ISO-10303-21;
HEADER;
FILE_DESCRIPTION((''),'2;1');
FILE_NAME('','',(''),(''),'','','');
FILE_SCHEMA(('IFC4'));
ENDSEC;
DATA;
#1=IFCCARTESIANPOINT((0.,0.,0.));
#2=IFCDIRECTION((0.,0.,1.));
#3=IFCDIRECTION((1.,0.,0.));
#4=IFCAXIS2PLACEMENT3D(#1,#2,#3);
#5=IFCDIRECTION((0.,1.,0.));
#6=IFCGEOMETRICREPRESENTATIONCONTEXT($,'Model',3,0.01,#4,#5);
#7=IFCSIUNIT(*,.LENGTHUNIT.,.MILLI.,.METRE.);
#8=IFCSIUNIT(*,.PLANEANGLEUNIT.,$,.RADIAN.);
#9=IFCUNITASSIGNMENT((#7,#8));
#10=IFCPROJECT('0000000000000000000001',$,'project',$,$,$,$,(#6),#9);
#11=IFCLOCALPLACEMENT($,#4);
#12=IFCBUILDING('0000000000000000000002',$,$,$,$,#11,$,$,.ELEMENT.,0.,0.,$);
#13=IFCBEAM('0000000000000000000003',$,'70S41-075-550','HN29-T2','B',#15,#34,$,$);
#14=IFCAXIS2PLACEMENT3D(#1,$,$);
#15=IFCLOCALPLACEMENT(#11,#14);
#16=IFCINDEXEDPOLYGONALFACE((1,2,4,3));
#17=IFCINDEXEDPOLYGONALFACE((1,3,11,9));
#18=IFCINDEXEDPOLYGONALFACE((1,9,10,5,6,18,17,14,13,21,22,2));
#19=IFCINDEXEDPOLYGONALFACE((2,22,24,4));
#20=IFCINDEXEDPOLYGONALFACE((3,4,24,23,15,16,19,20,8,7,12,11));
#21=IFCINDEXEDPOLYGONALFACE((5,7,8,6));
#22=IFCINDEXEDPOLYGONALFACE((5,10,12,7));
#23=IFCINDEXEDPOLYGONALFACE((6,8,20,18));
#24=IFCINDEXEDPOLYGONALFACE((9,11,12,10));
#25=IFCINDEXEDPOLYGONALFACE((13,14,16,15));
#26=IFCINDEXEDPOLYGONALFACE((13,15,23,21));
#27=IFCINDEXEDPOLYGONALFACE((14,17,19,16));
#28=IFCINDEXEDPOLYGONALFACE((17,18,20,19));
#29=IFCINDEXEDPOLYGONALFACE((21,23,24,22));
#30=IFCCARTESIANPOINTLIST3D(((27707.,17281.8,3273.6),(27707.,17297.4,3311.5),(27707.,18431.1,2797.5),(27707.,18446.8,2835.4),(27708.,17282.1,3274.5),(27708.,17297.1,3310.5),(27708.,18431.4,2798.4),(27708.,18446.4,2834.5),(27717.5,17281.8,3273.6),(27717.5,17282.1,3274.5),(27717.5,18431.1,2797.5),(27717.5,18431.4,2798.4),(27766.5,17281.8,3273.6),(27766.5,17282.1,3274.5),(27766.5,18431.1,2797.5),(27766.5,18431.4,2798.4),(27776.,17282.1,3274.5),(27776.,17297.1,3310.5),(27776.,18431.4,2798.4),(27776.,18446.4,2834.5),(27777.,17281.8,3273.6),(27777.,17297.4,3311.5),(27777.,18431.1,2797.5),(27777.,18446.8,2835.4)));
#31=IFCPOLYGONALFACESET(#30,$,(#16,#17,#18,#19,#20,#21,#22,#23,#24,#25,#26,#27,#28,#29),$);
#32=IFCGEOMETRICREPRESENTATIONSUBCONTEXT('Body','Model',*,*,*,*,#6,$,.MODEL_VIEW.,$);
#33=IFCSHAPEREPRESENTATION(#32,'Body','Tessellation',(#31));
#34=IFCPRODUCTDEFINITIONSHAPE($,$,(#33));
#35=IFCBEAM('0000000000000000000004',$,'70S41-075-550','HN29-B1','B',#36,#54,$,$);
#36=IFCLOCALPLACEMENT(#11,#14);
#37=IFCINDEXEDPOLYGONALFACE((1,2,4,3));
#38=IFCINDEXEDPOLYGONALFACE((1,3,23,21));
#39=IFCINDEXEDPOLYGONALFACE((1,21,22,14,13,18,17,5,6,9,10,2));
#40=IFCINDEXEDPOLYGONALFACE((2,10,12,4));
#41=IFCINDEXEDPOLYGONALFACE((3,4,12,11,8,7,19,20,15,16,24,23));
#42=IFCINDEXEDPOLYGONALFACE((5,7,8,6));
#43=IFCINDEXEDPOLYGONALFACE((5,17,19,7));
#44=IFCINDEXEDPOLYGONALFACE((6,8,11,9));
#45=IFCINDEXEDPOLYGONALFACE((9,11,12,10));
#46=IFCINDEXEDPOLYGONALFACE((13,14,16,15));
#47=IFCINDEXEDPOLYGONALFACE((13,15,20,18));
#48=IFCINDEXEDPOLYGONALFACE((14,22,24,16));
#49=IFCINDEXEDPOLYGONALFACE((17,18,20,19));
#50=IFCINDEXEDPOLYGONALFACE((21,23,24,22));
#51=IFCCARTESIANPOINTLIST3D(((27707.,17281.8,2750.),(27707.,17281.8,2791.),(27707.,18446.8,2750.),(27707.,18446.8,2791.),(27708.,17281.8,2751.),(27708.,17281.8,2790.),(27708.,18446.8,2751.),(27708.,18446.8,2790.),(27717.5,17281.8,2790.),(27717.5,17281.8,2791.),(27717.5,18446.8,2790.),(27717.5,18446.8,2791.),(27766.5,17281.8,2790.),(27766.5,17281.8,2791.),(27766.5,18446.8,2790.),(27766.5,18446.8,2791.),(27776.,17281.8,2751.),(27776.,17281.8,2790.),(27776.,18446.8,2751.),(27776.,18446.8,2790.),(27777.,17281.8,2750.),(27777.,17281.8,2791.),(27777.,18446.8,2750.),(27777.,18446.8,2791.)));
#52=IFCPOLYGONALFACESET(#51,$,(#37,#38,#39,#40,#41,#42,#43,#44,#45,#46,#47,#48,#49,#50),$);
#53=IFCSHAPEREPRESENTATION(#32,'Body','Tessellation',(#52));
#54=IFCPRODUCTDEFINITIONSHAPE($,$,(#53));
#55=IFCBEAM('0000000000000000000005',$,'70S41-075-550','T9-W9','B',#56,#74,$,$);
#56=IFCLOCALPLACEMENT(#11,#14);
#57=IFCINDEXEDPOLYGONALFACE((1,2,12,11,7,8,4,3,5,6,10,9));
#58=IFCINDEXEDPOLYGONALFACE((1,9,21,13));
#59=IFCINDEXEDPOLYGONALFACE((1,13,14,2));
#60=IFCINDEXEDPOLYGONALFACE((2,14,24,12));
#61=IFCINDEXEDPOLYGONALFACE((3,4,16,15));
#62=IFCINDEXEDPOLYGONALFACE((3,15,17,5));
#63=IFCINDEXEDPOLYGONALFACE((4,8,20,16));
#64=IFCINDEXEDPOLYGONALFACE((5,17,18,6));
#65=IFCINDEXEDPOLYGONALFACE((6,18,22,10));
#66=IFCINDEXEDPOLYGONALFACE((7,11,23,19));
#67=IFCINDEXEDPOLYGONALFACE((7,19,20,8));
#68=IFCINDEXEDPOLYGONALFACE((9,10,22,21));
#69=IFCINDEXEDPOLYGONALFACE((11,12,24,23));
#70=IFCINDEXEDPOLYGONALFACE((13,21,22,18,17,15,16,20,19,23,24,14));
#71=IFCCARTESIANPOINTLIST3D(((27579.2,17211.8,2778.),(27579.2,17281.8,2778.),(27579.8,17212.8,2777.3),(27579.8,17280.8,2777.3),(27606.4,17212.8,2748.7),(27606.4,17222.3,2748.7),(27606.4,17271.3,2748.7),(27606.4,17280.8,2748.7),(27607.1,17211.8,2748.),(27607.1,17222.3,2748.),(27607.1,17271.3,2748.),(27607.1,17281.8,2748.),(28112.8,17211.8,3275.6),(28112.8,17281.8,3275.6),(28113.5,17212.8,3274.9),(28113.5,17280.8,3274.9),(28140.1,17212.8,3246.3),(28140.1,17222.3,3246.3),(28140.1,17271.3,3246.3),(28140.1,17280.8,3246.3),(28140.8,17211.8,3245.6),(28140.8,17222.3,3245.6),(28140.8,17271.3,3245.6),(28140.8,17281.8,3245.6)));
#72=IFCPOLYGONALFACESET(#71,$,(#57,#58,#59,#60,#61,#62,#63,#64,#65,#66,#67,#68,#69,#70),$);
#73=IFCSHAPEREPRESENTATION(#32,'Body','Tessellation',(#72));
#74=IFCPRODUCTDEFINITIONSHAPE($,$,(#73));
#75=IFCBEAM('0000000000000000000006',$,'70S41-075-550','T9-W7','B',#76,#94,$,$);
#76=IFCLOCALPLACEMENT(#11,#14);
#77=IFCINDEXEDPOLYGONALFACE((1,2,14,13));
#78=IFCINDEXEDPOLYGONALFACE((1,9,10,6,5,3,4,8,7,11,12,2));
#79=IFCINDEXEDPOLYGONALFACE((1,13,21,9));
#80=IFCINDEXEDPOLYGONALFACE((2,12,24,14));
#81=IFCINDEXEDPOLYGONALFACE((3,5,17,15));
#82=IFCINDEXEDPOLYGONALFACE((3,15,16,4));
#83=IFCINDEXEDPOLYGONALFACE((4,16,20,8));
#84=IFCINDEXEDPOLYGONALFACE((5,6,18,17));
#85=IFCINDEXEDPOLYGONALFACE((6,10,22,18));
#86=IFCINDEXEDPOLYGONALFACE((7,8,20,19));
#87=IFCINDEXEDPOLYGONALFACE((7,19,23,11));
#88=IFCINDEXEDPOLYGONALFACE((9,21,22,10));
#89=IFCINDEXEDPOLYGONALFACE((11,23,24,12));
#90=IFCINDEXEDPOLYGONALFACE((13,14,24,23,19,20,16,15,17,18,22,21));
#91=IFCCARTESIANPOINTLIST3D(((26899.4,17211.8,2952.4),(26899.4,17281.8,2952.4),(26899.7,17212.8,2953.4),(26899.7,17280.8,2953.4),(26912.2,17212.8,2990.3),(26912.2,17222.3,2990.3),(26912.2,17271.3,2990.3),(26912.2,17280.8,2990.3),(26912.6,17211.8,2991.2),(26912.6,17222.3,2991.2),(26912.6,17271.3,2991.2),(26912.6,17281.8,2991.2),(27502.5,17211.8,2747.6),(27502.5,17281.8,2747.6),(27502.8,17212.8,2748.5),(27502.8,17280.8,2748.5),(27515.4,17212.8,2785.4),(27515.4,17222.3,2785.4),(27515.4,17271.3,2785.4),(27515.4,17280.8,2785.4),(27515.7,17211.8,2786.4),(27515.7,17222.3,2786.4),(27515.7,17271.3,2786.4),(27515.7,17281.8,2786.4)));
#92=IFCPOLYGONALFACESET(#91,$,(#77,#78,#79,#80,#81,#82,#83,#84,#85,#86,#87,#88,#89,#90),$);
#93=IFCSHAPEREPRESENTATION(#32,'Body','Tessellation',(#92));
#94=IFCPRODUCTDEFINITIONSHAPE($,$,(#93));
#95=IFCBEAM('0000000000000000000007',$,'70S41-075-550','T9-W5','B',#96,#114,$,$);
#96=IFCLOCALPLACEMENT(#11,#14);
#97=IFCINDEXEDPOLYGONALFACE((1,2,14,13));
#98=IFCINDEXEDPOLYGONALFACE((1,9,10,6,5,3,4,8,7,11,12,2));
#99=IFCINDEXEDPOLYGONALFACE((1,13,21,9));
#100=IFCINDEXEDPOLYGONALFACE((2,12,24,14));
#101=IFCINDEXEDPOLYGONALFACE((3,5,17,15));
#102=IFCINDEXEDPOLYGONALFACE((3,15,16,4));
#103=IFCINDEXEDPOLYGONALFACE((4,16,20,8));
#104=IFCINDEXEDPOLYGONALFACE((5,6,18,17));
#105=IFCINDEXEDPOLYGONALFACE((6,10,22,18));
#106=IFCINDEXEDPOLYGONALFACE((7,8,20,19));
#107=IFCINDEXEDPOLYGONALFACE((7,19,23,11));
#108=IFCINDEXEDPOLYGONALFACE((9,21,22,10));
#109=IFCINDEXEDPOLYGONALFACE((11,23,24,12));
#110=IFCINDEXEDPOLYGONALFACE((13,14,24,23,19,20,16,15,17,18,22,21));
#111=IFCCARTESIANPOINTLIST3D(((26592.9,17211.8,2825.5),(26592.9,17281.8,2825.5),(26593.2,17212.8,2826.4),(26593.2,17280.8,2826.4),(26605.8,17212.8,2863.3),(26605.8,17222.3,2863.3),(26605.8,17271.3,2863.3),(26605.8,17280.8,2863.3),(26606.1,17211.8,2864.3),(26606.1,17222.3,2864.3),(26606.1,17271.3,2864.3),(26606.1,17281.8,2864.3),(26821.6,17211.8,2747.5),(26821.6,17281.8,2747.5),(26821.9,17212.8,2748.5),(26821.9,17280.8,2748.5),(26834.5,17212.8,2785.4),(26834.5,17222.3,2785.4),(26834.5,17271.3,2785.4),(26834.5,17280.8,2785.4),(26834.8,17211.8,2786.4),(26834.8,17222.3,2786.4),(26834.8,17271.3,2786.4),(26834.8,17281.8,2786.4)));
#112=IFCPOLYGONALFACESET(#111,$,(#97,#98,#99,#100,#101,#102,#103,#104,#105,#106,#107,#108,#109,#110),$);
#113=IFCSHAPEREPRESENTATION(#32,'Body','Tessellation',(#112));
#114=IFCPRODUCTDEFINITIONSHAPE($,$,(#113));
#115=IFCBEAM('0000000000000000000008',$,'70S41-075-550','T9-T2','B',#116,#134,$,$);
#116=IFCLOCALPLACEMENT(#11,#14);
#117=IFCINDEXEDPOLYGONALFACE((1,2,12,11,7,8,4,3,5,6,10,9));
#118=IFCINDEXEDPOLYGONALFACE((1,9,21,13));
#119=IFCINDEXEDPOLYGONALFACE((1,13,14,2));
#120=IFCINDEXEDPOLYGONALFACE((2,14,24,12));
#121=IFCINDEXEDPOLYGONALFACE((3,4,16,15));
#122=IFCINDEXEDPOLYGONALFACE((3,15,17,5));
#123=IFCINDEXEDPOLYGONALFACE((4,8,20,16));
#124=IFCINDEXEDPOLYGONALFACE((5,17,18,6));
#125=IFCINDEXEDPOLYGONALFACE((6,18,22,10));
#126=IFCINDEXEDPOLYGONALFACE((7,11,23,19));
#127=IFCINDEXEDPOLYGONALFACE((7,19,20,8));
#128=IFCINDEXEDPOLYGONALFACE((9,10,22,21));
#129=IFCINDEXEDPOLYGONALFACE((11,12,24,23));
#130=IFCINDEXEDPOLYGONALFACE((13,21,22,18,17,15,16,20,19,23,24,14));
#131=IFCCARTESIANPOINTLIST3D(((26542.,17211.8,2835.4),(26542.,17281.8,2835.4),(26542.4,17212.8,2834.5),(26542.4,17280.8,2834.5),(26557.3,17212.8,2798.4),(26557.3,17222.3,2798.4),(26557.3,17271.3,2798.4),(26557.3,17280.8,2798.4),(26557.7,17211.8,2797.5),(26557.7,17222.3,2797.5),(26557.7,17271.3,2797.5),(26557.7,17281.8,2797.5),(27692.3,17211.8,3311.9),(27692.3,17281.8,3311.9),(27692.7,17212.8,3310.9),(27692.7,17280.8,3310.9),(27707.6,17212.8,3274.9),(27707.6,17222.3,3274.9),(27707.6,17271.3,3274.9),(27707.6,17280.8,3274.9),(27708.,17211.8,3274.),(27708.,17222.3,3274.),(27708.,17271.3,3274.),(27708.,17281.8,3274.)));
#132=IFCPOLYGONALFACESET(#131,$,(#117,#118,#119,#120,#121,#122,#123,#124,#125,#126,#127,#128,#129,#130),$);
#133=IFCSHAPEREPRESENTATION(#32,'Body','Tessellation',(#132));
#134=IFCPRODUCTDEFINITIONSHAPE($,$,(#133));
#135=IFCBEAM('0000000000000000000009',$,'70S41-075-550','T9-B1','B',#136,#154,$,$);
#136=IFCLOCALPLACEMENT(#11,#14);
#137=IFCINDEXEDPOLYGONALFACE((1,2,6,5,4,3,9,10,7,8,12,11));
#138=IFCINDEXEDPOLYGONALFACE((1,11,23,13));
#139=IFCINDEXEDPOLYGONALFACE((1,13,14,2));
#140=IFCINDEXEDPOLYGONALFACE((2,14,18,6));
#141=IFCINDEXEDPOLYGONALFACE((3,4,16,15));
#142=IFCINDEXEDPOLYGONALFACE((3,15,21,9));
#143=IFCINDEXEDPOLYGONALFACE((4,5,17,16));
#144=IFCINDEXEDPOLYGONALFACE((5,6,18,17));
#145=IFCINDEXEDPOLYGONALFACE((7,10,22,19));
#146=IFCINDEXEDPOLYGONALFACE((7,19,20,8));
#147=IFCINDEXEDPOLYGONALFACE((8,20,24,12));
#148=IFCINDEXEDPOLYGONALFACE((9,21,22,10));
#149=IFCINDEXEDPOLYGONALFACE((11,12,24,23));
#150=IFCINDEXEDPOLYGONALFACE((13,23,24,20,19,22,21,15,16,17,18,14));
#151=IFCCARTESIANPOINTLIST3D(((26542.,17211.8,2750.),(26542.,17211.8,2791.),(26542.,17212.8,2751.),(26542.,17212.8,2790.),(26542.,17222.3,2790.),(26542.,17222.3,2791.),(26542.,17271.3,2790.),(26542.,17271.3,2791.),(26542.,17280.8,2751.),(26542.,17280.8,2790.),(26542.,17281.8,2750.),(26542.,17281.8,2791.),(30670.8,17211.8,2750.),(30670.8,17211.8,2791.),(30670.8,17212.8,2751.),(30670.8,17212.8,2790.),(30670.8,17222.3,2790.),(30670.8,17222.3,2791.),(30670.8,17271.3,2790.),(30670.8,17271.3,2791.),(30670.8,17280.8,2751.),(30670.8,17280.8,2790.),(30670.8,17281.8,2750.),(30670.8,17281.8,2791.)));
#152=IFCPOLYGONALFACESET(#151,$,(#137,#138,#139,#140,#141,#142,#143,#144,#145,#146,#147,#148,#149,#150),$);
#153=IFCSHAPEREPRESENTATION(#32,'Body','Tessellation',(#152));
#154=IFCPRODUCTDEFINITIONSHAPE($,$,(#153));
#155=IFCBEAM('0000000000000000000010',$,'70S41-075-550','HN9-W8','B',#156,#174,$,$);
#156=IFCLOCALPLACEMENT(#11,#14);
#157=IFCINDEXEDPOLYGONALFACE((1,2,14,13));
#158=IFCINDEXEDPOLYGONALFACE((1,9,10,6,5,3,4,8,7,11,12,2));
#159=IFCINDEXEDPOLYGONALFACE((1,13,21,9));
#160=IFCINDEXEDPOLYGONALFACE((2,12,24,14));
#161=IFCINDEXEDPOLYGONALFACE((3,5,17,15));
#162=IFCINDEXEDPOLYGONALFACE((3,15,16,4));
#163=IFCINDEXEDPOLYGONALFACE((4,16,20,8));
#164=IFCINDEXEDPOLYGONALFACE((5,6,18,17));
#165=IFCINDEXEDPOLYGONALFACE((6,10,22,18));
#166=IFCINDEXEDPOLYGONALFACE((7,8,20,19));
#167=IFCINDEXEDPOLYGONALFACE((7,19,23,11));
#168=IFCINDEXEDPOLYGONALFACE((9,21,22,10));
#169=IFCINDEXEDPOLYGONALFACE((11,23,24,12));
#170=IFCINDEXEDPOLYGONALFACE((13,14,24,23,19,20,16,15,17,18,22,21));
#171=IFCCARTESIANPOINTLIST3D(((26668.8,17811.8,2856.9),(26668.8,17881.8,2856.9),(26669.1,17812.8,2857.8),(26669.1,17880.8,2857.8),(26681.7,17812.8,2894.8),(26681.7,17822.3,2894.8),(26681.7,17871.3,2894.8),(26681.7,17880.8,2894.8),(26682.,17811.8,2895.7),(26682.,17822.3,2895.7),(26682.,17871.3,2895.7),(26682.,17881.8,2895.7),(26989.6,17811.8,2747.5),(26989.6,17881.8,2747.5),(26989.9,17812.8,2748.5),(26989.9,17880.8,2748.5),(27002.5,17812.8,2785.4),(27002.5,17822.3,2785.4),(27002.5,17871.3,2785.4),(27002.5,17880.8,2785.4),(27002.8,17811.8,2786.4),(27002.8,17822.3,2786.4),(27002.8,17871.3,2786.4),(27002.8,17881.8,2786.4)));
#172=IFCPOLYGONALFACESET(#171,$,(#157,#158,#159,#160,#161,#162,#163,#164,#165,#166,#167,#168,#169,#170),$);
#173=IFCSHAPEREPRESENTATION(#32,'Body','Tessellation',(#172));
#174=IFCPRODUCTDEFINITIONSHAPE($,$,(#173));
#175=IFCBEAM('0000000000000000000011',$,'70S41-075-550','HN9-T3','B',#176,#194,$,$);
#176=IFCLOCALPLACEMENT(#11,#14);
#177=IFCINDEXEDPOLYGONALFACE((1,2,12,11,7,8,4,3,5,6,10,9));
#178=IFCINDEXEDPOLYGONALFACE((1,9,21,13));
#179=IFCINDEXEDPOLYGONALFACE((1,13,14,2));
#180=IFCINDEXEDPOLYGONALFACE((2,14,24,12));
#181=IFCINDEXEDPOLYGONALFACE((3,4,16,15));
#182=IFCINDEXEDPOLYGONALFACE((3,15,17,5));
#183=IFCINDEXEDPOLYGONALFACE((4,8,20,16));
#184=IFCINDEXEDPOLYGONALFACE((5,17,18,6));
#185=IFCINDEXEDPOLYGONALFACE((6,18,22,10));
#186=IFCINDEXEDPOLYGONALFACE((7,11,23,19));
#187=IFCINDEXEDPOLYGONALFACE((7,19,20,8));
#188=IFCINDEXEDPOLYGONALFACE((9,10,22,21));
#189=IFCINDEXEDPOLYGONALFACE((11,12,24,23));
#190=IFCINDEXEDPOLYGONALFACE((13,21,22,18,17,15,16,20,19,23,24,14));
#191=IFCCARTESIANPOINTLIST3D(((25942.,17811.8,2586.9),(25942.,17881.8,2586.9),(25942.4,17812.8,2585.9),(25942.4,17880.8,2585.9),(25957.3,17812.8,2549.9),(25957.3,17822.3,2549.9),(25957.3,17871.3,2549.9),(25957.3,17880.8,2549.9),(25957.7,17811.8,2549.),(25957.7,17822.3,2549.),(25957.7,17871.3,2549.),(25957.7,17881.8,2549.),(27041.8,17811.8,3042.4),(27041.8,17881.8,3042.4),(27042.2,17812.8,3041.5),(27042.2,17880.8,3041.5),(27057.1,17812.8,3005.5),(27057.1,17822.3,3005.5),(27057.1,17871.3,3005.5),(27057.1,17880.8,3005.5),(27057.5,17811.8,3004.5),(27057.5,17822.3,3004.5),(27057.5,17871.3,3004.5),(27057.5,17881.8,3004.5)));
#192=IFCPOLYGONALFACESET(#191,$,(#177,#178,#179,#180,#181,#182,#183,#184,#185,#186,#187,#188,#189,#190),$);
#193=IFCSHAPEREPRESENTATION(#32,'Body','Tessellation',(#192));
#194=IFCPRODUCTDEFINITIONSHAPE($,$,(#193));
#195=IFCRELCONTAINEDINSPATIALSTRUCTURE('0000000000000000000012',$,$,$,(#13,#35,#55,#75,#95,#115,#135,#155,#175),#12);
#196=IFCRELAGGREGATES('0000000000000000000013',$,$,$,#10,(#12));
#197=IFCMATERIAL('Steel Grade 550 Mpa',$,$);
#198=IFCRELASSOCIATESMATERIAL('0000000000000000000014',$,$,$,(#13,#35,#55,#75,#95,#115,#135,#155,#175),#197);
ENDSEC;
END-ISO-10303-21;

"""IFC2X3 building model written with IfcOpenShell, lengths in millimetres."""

from ifc_helpers import new_model, si_unit, direction, frame, origin, origin_with_axes, origin_2d_with_axis, place, context, subcontext, project, spatial, c_section, extrude, source, transform, mapped, material, element, save


model = new_model("IFC2X3")

# Units and contexts
model_context = context("Model", 3, precision=0.01, world=origin_with_axes(), true_north=direction((0.0, 1.0, 0.0)))
body_context = subcontext(model_context, "Body", "Model", "MODEL_VIEW")
ifc_project = project(units=[si_unit("LENGTHUNIT", "METRE", prefix="MILLI"), si_unit("PLANEANGLEUNIT", "RADIAN")], contexts=[model_context])

# Building
building_placement = place(None, origin_with_axes())
building = spatial("IfcBuilding", under=ifc_project, at=building_placement, CompositionType="ELEMENT", ElevationOfRefHeight=0.0, ElevationOfTerrain=0.0)

# Shared definitions
ifc_material = material(Name="Steel Grade 550 Mpa")

# Beams
shared_shape_1 = source(origin(), body_context, "Body", "SweptSolid", [
    extrude(c_section(Depth=70.0, Width=41.0, WallThickness=1.0, Girth=10.5, at=origin_2d_with_axis()), origin_with_axes(), (0.0, 0.0, 1.0), 1244.0),
])
beam_1_placement = place(None, frame((27742.0, 17289.6, 3292.5), z_axis=(0.0, 0.92388, -0.382683), x_axis=(0.0, -0.382683, -0.92388)))
element("IfcBeam", 1, at=beam_1_placement, inside=building, material=ifc_material, Name="70S41-075-550", Description="HN29-T2", ObjectType="B", context=body_context, shape_type="MappedRepresentation", body=[
    mapped(shared_shape_1, transform((0.0, 0.0, 0.0), scale=1.0)),
])
shared_shape_2 = source(origin(), body_context, "Body", "SweptSolid", [
    extrude(c_section(Depth=70.0, Width=41.0, WallThickness=1.0, Girth=10.5, at=origin_2d_with_axis()), origin_with_axes(), (0.0, 0.0, 1.0), 1165.0),
])
beam_2_placement = place(None, frame((27742.0, 18446.8, 2770.5), z_axis=(0.0, -1.0, 0.0), x_axis=(0.0, 0.0, 1.0)))
element("IfcBeam", 2, at=beam_2_placement, inside=building, material=ifc_material, Name="70S41-075-550", Description="HN29-B1", ObjectType="B", context=body_context, shape_type="MappedRepresentation", body=[
    mapped(shared_shape_2, transform((0.0, 0.0, 0.0), scale=1.0)),
])
shared_shape_3 = source(origin(), body_context, "Body", "SweptSolid", [
    extrude(c_section(Depth=70.0, Width=41.0, WallThickness=1.0, Girth=10.5, at=origin_2d_with_axis()), origin_with_axes(), (0.0, 0.0, 1.0), 729.7),
])
beam_3_placement = place(None, frame((28126.8, 17246.8, 3260.6), z_axis=(-0.731389, 0.0, -0.681961), x_axis=(0.681961, 0.0, -0.731389)))
element("IfcBeam", 3, at=beam_3_placement, inside=building, material=ifc_material, Name="70S41-075-550", Description="T9-W9", ObjectType="B", context=body_context, shape_type="MappedRepresentation", body=[
    mapped(shared_shape_3, transform((0.0, 0.0, 0.0), scale=1.0)),
])
shared_shape_4 = source(origin(), body_context, "Body", "SweptSolid", [
    extrude(c_section(Depth=70.0, Width=41.0, WallThickness=1.0, Girth=10.5, at=origin_2d_with_axis()), origin_with_axes(), (0.0, 0.0, 1.0), 637.0),
])
beam_4_placement = place(None, frame((26906.0, 17246.8, 2971.8), z_axis=(0.946874, 0.0, -0.321605), x_axis=(0.321605, 0.0, 0.946874)))
element("IfcBeam", 4, at=beam_4_placement, inside=building, material=ifc_material, Name="70S41-075-550", Description="T9-W7", ObjectType="B", context=body_context, shape_type="MappedRepresentation", body=[
    mapped(shared_shape_4, transform((0.0, 0.0, 0.0), scale=1.0)),
])
shared_shape_5 = source(origin(), body_context, "Body", "SweptSolid", [
    extrude(c_section(Depth=70.0, Width=41.0, WallThickness=1.0, Girth=10.5, at=origin_2d_with_axis()), origin_with_axes(), (0.0, 0.0, 1.0), 241.6),
])
beam_5_placement = place(None, frame((26599.5, 17246.8, 2844.9), z_axis=(0.9466, 0.0, -0.322409), x_axis=(0.322409, 0.0, 0.9466)))
element("IfcBeam", 5, at=beam_5_placement, inside=building, material=ifc_material, Name="70S41-075-550", Description="T9-W5", ObjectType="B", context=body_context, shape_type="MappedRepresentation", body=[
    mapped(shared_shape_5, transform((0.0, 0.0, 0.0), scale=1.0)),
])
shared_shape_6 = source(origin(), body_context, "Body", "SweptSolid", [
    extrude(c_section(Depth=70.0, Width=41.0, WallThickness=1.0, Girth=10.5, at=origin_2d_with_axis()), origin_with_axes(), (0.0, 0.0, 1.0), 1245.1),
])
beam_6_placement = place(None, frame((27700.2, 17246.8, 3292.9), z_axis=(-0.92388, 0.0, -0.382683), x_axis=(0.382683, 0.0, -0.92388)))
element("IfcBeam", 6, at=beam_6_placement, inside=building, material=ifc_material, Name="70S41-075-550", Description="T9-T2", ObjectType="B", context=body_context, shape_type="MappedRepresentation", body=[
    mapped(shared_shape_6, transform((0.0, 0.0, 0.0), scale=1.0)),
])
shared_shape_7 = source(origin(), body_context, "Body", "SweptSolid", [
    extrude(c_section(Depth=70.0, Width=41.0, WallThickness=1.0, Girth=10.5, at=origin_2d_with_axis()), origin_with_axes(), (0.0, 0.0, 1.0), 4128.8),
])
beam_7_placement = place(None, frame((26542.0, 17246.8, 2770.5), z_axis=(1.0, 0.0, 0.0), x_axis=(0.0, 0.0, 1.0)))
element("IfcBeam", 7, at=beam_7_placement, inside=building, material=ifc_material, Name="70S41-075-550", Description="T9-B1", ObjectType="B", context=body_context, shape_type="MappedRepresentation", body=[
    mapped(shared_shape_7, transform((0.0, 0.0, 0.0), scale=1.0)),
])
shared_shape_8 = source(origin(), body_context, "Body", "SweptSolid", [
    extrude(c_section(Depth=70.0, Width=41.0, WallThickness=1.0, Girth=10.5, at=origin_2d_with_axis()), origin_with_axes(), (0.0, 0.0, 1.0), 338.9),
])
beam_8_placement = place(None, frame((26675.4, 17846.8, 2876.3), z_axis=(0.946528, 0.0, -0.322621), x_axis=(0.322621, 0.0, 0.946528)))
element("IfcBeam", 8, at=beam_8_placement, inside=building, material=ifc_material, Name="70S41-075-550", Description="HN9-W8", ObjectType="B", context=body_context, shape_type="MappedRepresentation", body=[
    mapped(shared_shape_8, transform((0.0, 0.0, 0.0), scale=1.0)),
])
shared_shape_9 = source(origin(), body_context, "Body", "SweptSolid", [
    extrude(c_section(Depth=70.0, Width=41.0, WallThickness=1.0, Girth=10.5, at=origin_2d_with_axis()), origin_with_axes(), (0.0, 0.0, 1.0), 1190.4),
])
beam_9_placement = place(None, frame((27049.7, 17846.8, 3023.5), z_axis=(-0.92388, 0.0, -0.382683), x_axis=(0.382683, 0.0, -0.92388)))
element("IfcBeam", 9, at=beam_9_placement, inside=building, material=ifc_material, Name="70S41-075-550", Description="HN9-T3", ObjectType="B", context=body_context, shape_type="MappedRepresentation", body=[
    mapped(shared_shape_9, transform((0.0, 0.0, 0.0), scale=1.0)),
])

save(model, "model.ifc")
